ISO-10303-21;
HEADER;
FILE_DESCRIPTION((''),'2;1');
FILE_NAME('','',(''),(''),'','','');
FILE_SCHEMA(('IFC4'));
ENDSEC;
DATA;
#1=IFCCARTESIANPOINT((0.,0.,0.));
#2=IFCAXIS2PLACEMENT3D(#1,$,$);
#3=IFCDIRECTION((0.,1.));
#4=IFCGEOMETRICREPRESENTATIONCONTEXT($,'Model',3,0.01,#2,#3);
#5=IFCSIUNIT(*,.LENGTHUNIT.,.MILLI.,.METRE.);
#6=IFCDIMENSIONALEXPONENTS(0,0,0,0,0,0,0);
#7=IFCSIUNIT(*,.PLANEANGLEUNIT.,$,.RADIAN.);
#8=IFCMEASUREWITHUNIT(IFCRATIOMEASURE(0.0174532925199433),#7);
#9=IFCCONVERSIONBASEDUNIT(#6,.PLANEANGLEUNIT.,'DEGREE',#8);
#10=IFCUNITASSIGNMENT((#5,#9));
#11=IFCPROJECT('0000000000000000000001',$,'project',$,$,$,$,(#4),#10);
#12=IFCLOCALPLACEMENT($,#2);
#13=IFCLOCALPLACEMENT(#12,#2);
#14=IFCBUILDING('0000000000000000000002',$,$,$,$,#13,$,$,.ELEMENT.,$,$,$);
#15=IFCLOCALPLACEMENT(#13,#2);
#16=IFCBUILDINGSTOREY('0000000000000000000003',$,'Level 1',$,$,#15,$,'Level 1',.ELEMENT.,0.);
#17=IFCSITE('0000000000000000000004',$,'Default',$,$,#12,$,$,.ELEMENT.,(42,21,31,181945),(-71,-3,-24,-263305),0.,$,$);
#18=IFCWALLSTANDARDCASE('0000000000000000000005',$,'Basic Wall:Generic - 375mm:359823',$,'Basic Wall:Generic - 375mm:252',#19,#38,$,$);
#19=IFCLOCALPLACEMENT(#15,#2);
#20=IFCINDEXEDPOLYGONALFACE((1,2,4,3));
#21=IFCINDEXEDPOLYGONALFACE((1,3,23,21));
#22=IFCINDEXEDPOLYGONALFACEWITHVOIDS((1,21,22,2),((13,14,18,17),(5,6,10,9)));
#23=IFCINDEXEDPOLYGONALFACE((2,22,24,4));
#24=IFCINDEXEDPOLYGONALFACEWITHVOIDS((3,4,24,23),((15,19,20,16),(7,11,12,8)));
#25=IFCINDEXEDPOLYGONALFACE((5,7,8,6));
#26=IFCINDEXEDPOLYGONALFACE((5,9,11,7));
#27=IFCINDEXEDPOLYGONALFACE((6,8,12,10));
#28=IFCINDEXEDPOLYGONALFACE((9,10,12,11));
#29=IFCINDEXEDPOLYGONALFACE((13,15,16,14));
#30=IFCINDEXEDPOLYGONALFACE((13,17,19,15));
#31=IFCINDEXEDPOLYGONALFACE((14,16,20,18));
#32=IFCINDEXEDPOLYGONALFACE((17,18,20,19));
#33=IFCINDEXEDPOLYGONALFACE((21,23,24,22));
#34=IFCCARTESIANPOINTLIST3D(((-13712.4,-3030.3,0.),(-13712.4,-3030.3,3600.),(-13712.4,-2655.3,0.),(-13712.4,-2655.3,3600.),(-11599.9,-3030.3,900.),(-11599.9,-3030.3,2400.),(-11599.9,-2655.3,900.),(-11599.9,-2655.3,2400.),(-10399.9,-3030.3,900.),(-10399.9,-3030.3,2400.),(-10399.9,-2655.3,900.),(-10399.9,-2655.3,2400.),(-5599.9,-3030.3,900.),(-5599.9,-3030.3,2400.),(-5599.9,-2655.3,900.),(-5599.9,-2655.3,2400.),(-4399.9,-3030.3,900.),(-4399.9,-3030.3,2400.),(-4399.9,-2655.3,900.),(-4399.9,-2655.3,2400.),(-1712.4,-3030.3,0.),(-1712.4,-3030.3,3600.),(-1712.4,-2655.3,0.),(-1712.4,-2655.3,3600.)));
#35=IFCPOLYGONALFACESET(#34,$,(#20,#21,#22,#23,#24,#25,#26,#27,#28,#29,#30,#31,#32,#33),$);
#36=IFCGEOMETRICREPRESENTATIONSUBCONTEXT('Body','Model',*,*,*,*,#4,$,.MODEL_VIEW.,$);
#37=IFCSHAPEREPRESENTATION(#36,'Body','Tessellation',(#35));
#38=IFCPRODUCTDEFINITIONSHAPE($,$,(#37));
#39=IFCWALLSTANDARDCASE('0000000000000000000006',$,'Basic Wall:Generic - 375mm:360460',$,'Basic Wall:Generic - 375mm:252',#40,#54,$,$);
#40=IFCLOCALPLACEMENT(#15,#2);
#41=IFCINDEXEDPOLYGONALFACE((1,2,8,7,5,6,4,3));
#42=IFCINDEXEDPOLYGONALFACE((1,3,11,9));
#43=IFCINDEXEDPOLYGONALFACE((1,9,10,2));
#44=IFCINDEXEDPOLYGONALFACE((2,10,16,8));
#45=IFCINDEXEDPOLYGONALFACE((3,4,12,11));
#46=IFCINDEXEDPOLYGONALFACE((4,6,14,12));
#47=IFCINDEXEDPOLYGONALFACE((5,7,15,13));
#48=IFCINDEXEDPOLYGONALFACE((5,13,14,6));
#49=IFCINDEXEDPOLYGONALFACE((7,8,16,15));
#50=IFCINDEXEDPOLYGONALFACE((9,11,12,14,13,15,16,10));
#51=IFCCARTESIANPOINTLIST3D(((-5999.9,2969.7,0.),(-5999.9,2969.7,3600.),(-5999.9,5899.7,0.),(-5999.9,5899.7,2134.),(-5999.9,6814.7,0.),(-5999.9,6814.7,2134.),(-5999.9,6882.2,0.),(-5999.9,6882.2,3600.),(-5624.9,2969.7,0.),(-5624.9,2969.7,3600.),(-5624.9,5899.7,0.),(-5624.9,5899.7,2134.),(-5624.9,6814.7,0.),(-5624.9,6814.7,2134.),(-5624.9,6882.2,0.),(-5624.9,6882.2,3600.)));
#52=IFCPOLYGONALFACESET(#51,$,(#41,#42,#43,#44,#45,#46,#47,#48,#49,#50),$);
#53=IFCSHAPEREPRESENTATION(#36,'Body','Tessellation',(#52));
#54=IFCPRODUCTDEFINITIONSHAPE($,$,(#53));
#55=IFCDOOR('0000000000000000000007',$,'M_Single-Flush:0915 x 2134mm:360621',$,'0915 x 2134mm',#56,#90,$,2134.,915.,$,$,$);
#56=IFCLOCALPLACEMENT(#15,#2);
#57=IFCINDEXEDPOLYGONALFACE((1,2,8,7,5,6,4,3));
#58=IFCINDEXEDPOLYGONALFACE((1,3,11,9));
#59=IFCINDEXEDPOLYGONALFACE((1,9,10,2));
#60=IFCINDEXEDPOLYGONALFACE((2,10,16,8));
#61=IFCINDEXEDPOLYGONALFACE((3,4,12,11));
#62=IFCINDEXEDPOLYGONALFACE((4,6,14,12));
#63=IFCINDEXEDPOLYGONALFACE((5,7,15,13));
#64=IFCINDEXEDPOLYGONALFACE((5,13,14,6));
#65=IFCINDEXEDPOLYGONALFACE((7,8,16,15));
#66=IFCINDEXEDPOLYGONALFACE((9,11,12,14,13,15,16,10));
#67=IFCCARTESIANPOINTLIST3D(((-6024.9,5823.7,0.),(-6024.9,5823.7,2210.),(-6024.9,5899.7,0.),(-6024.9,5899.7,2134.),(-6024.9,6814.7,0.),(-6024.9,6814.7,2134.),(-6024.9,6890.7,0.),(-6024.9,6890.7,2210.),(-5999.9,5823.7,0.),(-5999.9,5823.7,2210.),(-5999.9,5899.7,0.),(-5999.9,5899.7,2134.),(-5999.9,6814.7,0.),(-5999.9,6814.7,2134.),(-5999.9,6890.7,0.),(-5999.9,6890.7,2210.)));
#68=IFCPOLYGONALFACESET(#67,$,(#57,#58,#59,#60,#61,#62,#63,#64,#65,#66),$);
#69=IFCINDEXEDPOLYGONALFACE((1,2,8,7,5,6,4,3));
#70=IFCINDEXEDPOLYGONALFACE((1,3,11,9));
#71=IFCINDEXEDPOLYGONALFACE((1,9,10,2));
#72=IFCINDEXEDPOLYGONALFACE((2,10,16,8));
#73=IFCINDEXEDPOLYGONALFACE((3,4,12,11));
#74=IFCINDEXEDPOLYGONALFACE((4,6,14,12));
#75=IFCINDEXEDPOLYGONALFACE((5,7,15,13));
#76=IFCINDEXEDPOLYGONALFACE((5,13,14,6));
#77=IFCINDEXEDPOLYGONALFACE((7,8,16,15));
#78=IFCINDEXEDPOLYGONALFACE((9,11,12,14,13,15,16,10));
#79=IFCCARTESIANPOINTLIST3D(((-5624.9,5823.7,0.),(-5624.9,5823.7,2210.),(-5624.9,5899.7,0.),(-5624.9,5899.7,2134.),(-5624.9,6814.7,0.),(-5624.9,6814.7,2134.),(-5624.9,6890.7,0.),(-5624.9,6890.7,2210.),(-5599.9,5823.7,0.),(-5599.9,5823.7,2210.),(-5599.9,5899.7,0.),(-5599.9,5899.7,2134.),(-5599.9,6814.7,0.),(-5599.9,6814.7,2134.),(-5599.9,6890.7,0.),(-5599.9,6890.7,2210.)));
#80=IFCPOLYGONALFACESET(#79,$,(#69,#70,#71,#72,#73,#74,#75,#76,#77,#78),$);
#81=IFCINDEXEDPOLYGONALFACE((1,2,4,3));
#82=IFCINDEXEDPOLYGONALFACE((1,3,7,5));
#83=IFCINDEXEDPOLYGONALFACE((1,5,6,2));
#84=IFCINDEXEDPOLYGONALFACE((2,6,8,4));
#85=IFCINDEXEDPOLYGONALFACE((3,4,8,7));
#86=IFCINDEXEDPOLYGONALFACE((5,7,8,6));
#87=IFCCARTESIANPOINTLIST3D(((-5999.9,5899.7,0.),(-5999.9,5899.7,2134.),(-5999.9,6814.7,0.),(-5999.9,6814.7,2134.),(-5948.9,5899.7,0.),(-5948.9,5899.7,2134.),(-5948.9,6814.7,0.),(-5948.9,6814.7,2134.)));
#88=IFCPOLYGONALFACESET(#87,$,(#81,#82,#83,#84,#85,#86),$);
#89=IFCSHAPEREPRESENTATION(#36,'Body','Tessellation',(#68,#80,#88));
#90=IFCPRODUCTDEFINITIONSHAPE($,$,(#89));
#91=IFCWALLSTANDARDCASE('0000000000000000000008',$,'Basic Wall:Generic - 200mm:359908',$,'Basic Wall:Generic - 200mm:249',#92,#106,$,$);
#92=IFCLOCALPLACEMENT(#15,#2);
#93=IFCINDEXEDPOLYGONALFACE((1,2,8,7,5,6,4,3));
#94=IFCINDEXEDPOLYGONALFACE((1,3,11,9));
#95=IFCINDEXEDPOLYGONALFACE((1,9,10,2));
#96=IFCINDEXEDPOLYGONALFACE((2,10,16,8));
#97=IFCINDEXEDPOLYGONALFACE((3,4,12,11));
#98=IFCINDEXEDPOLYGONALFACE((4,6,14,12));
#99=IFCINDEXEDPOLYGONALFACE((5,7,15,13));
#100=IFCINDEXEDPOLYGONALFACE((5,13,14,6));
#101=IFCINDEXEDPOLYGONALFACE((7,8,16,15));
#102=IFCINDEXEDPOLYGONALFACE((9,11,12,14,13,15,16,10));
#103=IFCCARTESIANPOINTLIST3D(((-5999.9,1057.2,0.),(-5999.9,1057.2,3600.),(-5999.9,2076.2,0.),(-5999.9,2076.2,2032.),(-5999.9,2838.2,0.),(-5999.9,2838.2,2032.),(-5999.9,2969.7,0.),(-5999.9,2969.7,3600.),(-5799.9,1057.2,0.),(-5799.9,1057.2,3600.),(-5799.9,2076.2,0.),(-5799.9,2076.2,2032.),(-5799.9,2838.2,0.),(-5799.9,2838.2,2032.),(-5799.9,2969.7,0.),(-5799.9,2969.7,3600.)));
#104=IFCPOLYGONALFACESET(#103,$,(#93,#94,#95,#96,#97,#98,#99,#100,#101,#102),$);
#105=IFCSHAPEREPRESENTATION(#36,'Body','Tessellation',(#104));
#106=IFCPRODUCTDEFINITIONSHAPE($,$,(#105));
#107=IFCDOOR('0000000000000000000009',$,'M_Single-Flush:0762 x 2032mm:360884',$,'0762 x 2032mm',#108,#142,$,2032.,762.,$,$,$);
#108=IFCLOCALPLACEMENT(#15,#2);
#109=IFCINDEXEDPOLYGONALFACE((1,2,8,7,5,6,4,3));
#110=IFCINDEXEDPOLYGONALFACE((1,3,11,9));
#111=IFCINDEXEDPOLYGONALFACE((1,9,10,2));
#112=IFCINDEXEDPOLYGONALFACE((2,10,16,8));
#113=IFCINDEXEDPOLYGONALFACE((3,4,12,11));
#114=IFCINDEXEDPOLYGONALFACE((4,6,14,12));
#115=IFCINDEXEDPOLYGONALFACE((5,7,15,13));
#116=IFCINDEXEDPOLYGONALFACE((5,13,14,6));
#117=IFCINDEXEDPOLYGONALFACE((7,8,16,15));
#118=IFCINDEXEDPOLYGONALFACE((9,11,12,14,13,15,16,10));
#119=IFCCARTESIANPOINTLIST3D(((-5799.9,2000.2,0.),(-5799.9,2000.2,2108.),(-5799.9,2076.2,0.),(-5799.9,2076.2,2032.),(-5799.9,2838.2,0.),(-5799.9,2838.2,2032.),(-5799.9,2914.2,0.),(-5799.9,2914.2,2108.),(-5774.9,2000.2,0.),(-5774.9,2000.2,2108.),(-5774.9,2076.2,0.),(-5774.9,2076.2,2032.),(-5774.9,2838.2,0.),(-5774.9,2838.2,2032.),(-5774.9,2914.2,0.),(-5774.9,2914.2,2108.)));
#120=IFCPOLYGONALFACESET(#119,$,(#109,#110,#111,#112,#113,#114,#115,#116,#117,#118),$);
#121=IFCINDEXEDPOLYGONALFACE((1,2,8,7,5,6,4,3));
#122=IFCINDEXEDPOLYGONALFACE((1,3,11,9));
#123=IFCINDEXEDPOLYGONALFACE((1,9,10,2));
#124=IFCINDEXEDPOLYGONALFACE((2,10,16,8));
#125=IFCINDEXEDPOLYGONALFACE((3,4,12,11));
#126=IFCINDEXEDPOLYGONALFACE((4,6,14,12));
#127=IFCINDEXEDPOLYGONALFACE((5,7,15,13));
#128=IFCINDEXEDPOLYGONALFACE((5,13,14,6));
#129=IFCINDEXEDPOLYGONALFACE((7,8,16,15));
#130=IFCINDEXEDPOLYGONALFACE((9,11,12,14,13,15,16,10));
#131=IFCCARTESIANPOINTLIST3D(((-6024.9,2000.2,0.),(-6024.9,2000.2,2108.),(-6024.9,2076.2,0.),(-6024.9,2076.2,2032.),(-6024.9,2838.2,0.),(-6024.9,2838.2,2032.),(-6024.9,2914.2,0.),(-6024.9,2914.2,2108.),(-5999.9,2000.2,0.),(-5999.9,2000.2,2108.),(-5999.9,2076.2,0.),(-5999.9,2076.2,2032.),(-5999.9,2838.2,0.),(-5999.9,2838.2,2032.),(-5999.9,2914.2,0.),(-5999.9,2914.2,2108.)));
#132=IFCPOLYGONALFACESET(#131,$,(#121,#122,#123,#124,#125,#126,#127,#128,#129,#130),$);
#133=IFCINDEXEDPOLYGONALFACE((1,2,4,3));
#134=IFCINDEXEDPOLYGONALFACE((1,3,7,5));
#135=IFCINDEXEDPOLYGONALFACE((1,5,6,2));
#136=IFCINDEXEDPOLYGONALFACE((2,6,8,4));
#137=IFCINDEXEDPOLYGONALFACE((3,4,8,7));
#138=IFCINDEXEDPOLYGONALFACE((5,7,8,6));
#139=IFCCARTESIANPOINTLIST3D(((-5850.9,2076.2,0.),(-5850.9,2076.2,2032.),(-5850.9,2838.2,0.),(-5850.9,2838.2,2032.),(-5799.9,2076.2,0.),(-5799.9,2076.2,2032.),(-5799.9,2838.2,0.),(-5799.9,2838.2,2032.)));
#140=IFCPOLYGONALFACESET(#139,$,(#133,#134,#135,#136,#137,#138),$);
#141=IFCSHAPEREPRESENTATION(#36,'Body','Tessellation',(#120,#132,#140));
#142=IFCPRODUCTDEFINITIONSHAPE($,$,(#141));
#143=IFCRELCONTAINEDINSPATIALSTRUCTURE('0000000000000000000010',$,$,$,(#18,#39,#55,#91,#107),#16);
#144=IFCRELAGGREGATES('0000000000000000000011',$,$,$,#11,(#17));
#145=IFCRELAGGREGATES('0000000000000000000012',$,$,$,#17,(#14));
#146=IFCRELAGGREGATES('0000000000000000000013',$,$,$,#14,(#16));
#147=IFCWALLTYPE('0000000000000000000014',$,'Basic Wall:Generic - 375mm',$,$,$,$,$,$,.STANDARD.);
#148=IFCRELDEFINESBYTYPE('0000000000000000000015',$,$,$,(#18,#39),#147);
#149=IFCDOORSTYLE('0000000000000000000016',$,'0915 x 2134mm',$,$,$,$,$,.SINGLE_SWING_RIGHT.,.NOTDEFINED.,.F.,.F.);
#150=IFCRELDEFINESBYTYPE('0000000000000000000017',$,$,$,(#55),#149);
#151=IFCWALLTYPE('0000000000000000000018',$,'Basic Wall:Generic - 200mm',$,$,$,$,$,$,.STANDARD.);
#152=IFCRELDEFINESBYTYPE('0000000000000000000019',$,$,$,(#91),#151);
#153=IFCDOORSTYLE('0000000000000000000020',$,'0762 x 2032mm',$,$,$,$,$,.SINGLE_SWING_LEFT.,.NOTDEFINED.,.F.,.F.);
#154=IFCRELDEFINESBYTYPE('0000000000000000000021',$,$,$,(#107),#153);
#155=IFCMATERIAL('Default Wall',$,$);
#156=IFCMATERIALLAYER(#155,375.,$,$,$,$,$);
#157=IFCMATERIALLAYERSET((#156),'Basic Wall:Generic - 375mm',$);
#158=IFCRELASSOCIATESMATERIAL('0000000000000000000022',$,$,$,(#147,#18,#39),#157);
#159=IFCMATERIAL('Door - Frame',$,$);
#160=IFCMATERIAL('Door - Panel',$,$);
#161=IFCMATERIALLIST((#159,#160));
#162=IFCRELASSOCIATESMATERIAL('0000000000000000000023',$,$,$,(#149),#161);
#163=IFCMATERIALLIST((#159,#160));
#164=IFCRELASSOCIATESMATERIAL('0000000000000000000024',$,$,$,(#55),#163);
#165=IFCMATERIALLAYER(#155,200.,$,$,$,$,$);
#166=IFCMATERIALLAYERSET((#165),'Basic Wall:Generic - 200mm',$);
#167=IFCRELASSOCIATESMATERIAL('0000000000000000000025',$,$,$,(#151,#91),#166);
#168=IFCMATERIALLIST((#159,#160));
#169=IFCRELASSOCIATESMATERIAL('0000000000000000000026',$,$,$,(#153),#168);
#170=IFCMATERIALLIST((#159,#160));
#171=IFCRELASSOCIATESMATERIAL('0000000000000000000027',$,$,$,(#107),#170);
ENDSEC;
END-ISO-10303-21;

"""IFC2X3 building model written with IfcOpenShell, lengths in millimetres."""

from ifc_helpers import new_model, entity, si_unit, converted_unit, direction, frame, frame_2d, origin, place, context, subcontext, project, spatial, polyline, rectangle, outline, extrude, clip, bounded_halfspace, source, transform, mapped, material, material_list, layer, layer_set, layer_usage, type_object, type_shapes, element, fill, save


model = new_model("IFC2X3")

# Units and contexts
model_context = context("Model", 3, precision=0.01, world=origin(), true_north=direction((0.0, 1.0)))
body_context = subcontext(model_context, "Body", "Model", "MODEL_VIEW")
ifc_project = project(units=[si_unit("LENGTHUNIT", "METRE", prefix="MILLI"), converted_unit("PLANEANGLEUNIT", "DEGREE", entity("IfcRatioMeasure", 0.0174532925199433), si_unit("PLANEANGLEUNIT", "RADIAN"), dimensions=[0, 0, 0, 0, 0, 0, 0])], contexts=[model_context])

# Site, building, storey
site_placement = place(None, origin())
site = spatial("IfcSite", under=ifc_project, at=site_placement, Name="Default", CompositionType="ELEMENT", RefLatitude=(42, 21, 31, 181945), RefLongitude=(-71, -3, -24, -263305), RefElevation=0.0)
building_placement = place(site_placement, origin())
building = spatial("IfcBuilding", under=site, at=building_placement, CompositionType="ELEMENT")
storey_placement = place(building_placement, origin())
storey = spatial("IfcBuildingStorey", under=building, at=storey_placement, Name="Level 1", LongName="Level 1", CompositionType="ELEMENT", Elevation=0.0)

# Wall, openings
ifc_material_1 = material(Name="Default Wall")
ifc_layer_1 = layer(ifc_material_1, 375.0)
ifc_layer_set_1 = layer_set([ifc_layer_1], Name="Basic Wall:Generic - 375mm")
ifc_layer_usage_1 = layer_usage(ifc_layer_set_1, "AXIS2", "NEGATIVE", 187.5)
wall_type_1 = type_object("IfcWallType", Name="Basic Wall:Generic - 375mm", PredefinedType="STANDARD", material=ifc_layer_set_1)
wall_1_placement = place(storey_placement, frame((-13712.4, -2842.8, 0.0)))
wall_1 = element("IfcWallStandardCase", 1, at=wall_1_placement, inside=storey, type_object=wall_type_1, material=ifc_layer_usage_1, Name="Basic Wall:Generic - 375mm:359823", ObjectType="Basic Wall:Generic - 375mm:252", context=body_context, shape_type="Clipping", body=[
    clip(extrude(rectangle(XDim=12000.0, YDim=375.0, at=frame_2d((6000.0, 0.0), x_axis=(-1.0, 0.0))), origin(), (0.0, 0.0, 1.0), 3600.0), bounded_halfspace(frame((0.0, -187.5, 3600.0), z_axis=(0.0, 0.0, -1.0), x_axis=(1.0, 0.0, 0.0)), True, frame((0.0, -187.5, 3600.0)), polyline([(0.0, 0.0), (12000.0, 0.0), (12000.0, 375.0), (11625.0, 375.0), (5712.5, 375.0), (5512.5, 375.0), (0.0, 375.0), (0.0, 0.0)]))),
])
opening_1_placement = place(wall_1_placement, frame((2112.5, -187.5, 900.0)))
element("IfcOpeningElement", 2, at=opening_1_placement, cuts=wall_1, ObjectType="Opening", context=body_context, shape_type="SweptSolid", body=[
    extrude(rectangle(XDim=1500.0, YDim=1200.0, at=frame_2d((750.0, 600.0), x_axis=(-1.0, 0.0))), frame((0.0, 0.0, 0.0), z_axis=(0.0, 1.0, 0.0), x_axis=(0.0, 0.0, 1.0)), (0.0, 0.0, 1.0), 375.0),
])
opening_2_placement = place(wall_1_placement, frame((8112.5, -187.5, 900.0)))
element("IfcOpeningElement", 3, at=opening_2_placement, cuts=wall_1, ObjectType="Opening", context=body_context, shape_type="SweptSolid", body=[
    extrude(rectangle(XDim=1500.0, YDim=1200.0, at=frame_2d((750.0, 600.0), x_axis=(-1.0, 0.0))), frame((0.0, 0.0, 0.0), z_axis=(0.0, 1.0, 0.0), x_axis=(0.0, 0.0, 1.0)), (0.0, 0.0, 1.0), 375.0),
])

# Walls, openings, doors
ifc_layer_usage_2 = layer_usage(ifc_layer_set_1, "AXIS2", "NEGATIVE", 187.5)
wall_2_placement = place(storey_placement, frame((-5812.4, 2969.7, 0.0), z_axis=(0.0, 0.0, 1.0), x_axis=(0.0, 1.0, 0.0)))
wall_2 = element("IfcWallStandardCase", 4, at=wall_2_placement, inside=storey, type_object=wall_type_1, material=ifc_layer_usage_2, Name="Basic Wall:Generic - 375mm:360460", ObjectType="Basic Wall:Generic - 375mm:252", context=body_context, shape_type="Clipping", body=[
    clip(extrude(rectangle(XDim=3912.5, YDim=375.0, at=frame_2d((1956.3, 0.0), x_axis=(-1.0, 0.0))), origin(), (0.0, 0.0, 1.0), 3600.0), bounded_halfspace(frame((0.0, -187.5, 3600.0), z_axis=(0.0, 0.0, -1.0), x_axis=(0.0, -1.0, 0.0)), True, frame((0.0, -187.5, 3600.0)), polyline([(0.0, 0.0), (375.0, 0.0), (3912.5, 0.0), (3912.5, 375.0), (0.0, 375.0), (0.0, 175.0), (0.0, 0.0)]))),
])
opening_3_placement = place(wall_2_placement, frame((2930.0, -187.5, 0.0)))
opening_3 = element("IfcOpeningElement", 5, at=opening_3_placement, cuts=wall_2, ObjectType="Opening", context=body_context, shape_type="SweptSolid", body=[
    extrude(rectangle(XDim=915.0, YDim=2134.0, at=frame_2d((1067.0, 457.5), x_axis=(0.0, 1.0))), frame((0.0, 0.0, 0.0), z_axis=(0.0, 1.0, 0.0), x_axis=(0.0, 0.0, 1.0)), (0.0, 0.0, 1.0), 375.0),
])
ifc_material_2 = material(Name="Door - Frame")
ifc_material_3 = material(Name="Door - Panel")
ifc_material_list_1 = material_list([ifc_material_2, ifc_material_3])
ifc_material_list_2 = material_list([ifc_material_2, ifc_material_3])
door_style_1 = type_object("IfcDoorStyle", Name="0915 x 2134mm", ConstructionType="NOTDEFINED", OperationType="SINGLE_SWING_RIGHT", ParameterTakesPrecedence=False, Sizeable=False, material=ifc_material_list_2)
shared_shape_1 = source(origin(), body_context, "Body", "SweptSolid", [
    extrude(outline(polyline([(-533.5, -1124.0), (533.5, -1124.0), (533.5, 1086.0), (457.5, 1086.0), (457.5, -1048.0), (-457.5, -1048.0), (-457.5, 1086.0), (-533.5, 1086.0), (-533.5, -1124.0)])), frame((457.5, 375.0, 1086.0), z_axis=(0.0, 1.0, 0.0), x_axis=(1.0, 0.0, 0.0)), (0.0, 0.0, 1.0), 25.0),
    extrude(outline(polyline([(-1124.0, -533.5), (1086.0, -533.5), (1086.0, -457.5), (-1048.0, -457.5), (-1048.0, 457.5), (1086.0, 457.5), (1086.0, 533.5), (-1124.0, 533.5), (-1124.0, -533.5)])), frame((457.5, -25.0, 1086.0), z_axis=(0.0, 1.0, 0.0), x_axis=(0.0, 0.0, -1.0)), (0.0, 0.0, 1.0), 25.0),
    extrude(rectangle(XDim=51.0, YDim=915.0, at=frame_2d((0.0, 0.0), x_axis=(1.0, 0.0))), frame((457.5, 349.5, 0.0), z_axis=(0.0, 0.0, 1.0), x_axis=(0.0, 1.0, 0.0)), (0.0, 0.0, 1.0), 2134.0),
])
type_shapes(door_style_1, [shared_shape_1])
door_1_placement = place(opening_3_placement, origin())
door_1 = element("IfcDoor", 6, at=door_1_placement, inside=storey, type_object=door_style_1, material=ifc_material_list_1, Name="M_Single-Flush:0915 x 2134mm:360621", ObjectType="0915 x 2134mm", OverallHeight=2134.0, OverallWidth=915.0, context=body_context, shape_type="MappedRepresentation", body=[
    mapped(shared_shape_1, transform((0.0, 0.0, 0.0), scale=1.0)),
])
fill(opening_3, door_1)
ifc_layer_2 = layer(ifc_material_1, 200.0)
ifc_layer_set_2 = layer_set([ifc_layer_2], Name="Basic Wall:Generic - 200mm")
ifc_layer_usage_3 = layer_usage(ifc_layer_set_2, "AXIS2", "NEGATIVE", 100.0)
wall_type_2 = type_object("IfcWallType", Name="Basic Wall:Generic - 200mm", PredefinedType="STANDARD", material=ifc_layer_set_2)
wall_3_placement = place(storey_placement, frame((-5899.9, 1057.2, 0.0), z_axis=(0.0, 0.0, 1.0), x_axis=(0.0, 1.0, 0.0)))
wall_3 = element("IfcWallStandardCase", 7, at=wall_3_placement, inside=storey, type_object=wall_type_2, material=ifc_layer_usage_3, Name="Basic Wall:Generic - 200mm:359908", ObjectType="Basic Wall:Generic - 200mm:249", context=body_context, shape_type="Clipping", body=[
    clip(extrude(rectangle(XDim=1912.5, YDim=200.0, at=frame_2d((956.3, 0.0), x_axis=(-1.0, 0.0))), origin(), (0.0, 0.0, 1.0), 3600.0), bounded_halfspace(frame((0.0, -100.0, 3600.0), z_axis=(0.0, 0.0, -1.0), x_axis=(0.0, -1.0, 0.0)), True, frame((0.0, -100.0, 3600.0)), polyline([(0.0, 0.0), (1912.5, 0.0), (1912.5, 200.0), (0.0, 200.0), (0.0, 0.0)]))),
])
opening_4_placement = place(wall_3_placement, frame((1781.0, 100.0, 0.0)))
opening_4 = element("IfcOpeningElement", 8, at=opening_4_placement, cuts=wall_3, ObjectType="Opening", context=body_context, shape_type="SweptSolid", body=[
    extrude(rectangle(XDim=762.0, YDim=2032.0, at=frame_2d((1016.0, 381.0), x_axis=(0.0, -1.0))), frame((0.0, 0.0, 0.0), z_axis=(0.0, -1.0, 0.0), x_axis=(0.0, 0.0, 1.0)), (0.0, 0.0, 1.0), 200.0),
])
ifc_material_list_3 = material_list([ifc_material_2, ifc_material_3])
ifc_material_list_4 = material_list([ifc_material_2, ifc_material_3])
door_style_2 = type_object("IfcDoorStyle", Name="0762 x 2032mm", ConstructionType="NOTDEFINED", OperationType="SINGLE_SWING_LEFT", ParameterTakesPrecedence=False, Sizeable=False, material=ifc_material_list_4)
shared_shape_2 = source(origin(), body_context, "Body", "SweptSolid", [
    extrude(outline(polyline([(-457.0, -1073.0), (457.0, -1073.0), (457.0, 1035.0), (381.0, 1035.0), (381.0, -997.0), (-381.0, -997.0), (-381.0, 1035.0), (-457.0, 1035.0), (-457.0, -1073.0)])), frame((381.0, 225.0, 1035.0), z_axis=(0.0, -1.0, 0.0), x_axis=(-1.0, 0.0, 0.0)), (0.0, 0.0, 1.0), 25.0),
    extrude(outline(polyline([(-1073.0, -457.0), (1035.0, -457.0), (1035.0, -381.0), (-997.0, -381.0), (-997.0, 381.0), (1035.0, 381.0), (1035.0, 457.0), (-1073.0, 457.0), (-1073.0, -457.0)])), frame((381.0, 0.0, 1035.0), z_axis=(0.0, -1.0, 0.0), x_axis=(0.0, 0.0, -1.0)), (0.0, 0.0, 1.0), 25.0),
    extrude(rectangle(XDim=762.0, YDim=51.0, at=frame_2d((0.0, 0.0), x_axis=(1.0, 0.0))), frame((381.0, 174.5, 0.0)), (0.0, 0.0, 1.0), 2032.0),
])
type_shapes(door_style_2, [shared_shape_2])
door_2_placement = place(opening_4_placement, frame((0.0, 0.0, 0.0), z_axis=(0.0, 0.0, 1.0), x_axis=(-1.0, 0.0, 0.0)))
door_2 = element("IfcDoor", 9, at=door_2_placement, inside=storey, type_object=door_style_2, material=ifc_material_list_3, Name="M_Single-Flush:0762 x 2032mm:360884", ObjectType="0762 x 2032mm", OverallHeight=2032.0, OverallWidth=762.0, context=body_context, shape_type="MappedRepresentation", body=[
    mapped(shared_shape_2, transform((0.0, 0.0, 0.0), scale=1.0)),
])
fill(opening_4, door_2)

save(model, "model.ifc")
